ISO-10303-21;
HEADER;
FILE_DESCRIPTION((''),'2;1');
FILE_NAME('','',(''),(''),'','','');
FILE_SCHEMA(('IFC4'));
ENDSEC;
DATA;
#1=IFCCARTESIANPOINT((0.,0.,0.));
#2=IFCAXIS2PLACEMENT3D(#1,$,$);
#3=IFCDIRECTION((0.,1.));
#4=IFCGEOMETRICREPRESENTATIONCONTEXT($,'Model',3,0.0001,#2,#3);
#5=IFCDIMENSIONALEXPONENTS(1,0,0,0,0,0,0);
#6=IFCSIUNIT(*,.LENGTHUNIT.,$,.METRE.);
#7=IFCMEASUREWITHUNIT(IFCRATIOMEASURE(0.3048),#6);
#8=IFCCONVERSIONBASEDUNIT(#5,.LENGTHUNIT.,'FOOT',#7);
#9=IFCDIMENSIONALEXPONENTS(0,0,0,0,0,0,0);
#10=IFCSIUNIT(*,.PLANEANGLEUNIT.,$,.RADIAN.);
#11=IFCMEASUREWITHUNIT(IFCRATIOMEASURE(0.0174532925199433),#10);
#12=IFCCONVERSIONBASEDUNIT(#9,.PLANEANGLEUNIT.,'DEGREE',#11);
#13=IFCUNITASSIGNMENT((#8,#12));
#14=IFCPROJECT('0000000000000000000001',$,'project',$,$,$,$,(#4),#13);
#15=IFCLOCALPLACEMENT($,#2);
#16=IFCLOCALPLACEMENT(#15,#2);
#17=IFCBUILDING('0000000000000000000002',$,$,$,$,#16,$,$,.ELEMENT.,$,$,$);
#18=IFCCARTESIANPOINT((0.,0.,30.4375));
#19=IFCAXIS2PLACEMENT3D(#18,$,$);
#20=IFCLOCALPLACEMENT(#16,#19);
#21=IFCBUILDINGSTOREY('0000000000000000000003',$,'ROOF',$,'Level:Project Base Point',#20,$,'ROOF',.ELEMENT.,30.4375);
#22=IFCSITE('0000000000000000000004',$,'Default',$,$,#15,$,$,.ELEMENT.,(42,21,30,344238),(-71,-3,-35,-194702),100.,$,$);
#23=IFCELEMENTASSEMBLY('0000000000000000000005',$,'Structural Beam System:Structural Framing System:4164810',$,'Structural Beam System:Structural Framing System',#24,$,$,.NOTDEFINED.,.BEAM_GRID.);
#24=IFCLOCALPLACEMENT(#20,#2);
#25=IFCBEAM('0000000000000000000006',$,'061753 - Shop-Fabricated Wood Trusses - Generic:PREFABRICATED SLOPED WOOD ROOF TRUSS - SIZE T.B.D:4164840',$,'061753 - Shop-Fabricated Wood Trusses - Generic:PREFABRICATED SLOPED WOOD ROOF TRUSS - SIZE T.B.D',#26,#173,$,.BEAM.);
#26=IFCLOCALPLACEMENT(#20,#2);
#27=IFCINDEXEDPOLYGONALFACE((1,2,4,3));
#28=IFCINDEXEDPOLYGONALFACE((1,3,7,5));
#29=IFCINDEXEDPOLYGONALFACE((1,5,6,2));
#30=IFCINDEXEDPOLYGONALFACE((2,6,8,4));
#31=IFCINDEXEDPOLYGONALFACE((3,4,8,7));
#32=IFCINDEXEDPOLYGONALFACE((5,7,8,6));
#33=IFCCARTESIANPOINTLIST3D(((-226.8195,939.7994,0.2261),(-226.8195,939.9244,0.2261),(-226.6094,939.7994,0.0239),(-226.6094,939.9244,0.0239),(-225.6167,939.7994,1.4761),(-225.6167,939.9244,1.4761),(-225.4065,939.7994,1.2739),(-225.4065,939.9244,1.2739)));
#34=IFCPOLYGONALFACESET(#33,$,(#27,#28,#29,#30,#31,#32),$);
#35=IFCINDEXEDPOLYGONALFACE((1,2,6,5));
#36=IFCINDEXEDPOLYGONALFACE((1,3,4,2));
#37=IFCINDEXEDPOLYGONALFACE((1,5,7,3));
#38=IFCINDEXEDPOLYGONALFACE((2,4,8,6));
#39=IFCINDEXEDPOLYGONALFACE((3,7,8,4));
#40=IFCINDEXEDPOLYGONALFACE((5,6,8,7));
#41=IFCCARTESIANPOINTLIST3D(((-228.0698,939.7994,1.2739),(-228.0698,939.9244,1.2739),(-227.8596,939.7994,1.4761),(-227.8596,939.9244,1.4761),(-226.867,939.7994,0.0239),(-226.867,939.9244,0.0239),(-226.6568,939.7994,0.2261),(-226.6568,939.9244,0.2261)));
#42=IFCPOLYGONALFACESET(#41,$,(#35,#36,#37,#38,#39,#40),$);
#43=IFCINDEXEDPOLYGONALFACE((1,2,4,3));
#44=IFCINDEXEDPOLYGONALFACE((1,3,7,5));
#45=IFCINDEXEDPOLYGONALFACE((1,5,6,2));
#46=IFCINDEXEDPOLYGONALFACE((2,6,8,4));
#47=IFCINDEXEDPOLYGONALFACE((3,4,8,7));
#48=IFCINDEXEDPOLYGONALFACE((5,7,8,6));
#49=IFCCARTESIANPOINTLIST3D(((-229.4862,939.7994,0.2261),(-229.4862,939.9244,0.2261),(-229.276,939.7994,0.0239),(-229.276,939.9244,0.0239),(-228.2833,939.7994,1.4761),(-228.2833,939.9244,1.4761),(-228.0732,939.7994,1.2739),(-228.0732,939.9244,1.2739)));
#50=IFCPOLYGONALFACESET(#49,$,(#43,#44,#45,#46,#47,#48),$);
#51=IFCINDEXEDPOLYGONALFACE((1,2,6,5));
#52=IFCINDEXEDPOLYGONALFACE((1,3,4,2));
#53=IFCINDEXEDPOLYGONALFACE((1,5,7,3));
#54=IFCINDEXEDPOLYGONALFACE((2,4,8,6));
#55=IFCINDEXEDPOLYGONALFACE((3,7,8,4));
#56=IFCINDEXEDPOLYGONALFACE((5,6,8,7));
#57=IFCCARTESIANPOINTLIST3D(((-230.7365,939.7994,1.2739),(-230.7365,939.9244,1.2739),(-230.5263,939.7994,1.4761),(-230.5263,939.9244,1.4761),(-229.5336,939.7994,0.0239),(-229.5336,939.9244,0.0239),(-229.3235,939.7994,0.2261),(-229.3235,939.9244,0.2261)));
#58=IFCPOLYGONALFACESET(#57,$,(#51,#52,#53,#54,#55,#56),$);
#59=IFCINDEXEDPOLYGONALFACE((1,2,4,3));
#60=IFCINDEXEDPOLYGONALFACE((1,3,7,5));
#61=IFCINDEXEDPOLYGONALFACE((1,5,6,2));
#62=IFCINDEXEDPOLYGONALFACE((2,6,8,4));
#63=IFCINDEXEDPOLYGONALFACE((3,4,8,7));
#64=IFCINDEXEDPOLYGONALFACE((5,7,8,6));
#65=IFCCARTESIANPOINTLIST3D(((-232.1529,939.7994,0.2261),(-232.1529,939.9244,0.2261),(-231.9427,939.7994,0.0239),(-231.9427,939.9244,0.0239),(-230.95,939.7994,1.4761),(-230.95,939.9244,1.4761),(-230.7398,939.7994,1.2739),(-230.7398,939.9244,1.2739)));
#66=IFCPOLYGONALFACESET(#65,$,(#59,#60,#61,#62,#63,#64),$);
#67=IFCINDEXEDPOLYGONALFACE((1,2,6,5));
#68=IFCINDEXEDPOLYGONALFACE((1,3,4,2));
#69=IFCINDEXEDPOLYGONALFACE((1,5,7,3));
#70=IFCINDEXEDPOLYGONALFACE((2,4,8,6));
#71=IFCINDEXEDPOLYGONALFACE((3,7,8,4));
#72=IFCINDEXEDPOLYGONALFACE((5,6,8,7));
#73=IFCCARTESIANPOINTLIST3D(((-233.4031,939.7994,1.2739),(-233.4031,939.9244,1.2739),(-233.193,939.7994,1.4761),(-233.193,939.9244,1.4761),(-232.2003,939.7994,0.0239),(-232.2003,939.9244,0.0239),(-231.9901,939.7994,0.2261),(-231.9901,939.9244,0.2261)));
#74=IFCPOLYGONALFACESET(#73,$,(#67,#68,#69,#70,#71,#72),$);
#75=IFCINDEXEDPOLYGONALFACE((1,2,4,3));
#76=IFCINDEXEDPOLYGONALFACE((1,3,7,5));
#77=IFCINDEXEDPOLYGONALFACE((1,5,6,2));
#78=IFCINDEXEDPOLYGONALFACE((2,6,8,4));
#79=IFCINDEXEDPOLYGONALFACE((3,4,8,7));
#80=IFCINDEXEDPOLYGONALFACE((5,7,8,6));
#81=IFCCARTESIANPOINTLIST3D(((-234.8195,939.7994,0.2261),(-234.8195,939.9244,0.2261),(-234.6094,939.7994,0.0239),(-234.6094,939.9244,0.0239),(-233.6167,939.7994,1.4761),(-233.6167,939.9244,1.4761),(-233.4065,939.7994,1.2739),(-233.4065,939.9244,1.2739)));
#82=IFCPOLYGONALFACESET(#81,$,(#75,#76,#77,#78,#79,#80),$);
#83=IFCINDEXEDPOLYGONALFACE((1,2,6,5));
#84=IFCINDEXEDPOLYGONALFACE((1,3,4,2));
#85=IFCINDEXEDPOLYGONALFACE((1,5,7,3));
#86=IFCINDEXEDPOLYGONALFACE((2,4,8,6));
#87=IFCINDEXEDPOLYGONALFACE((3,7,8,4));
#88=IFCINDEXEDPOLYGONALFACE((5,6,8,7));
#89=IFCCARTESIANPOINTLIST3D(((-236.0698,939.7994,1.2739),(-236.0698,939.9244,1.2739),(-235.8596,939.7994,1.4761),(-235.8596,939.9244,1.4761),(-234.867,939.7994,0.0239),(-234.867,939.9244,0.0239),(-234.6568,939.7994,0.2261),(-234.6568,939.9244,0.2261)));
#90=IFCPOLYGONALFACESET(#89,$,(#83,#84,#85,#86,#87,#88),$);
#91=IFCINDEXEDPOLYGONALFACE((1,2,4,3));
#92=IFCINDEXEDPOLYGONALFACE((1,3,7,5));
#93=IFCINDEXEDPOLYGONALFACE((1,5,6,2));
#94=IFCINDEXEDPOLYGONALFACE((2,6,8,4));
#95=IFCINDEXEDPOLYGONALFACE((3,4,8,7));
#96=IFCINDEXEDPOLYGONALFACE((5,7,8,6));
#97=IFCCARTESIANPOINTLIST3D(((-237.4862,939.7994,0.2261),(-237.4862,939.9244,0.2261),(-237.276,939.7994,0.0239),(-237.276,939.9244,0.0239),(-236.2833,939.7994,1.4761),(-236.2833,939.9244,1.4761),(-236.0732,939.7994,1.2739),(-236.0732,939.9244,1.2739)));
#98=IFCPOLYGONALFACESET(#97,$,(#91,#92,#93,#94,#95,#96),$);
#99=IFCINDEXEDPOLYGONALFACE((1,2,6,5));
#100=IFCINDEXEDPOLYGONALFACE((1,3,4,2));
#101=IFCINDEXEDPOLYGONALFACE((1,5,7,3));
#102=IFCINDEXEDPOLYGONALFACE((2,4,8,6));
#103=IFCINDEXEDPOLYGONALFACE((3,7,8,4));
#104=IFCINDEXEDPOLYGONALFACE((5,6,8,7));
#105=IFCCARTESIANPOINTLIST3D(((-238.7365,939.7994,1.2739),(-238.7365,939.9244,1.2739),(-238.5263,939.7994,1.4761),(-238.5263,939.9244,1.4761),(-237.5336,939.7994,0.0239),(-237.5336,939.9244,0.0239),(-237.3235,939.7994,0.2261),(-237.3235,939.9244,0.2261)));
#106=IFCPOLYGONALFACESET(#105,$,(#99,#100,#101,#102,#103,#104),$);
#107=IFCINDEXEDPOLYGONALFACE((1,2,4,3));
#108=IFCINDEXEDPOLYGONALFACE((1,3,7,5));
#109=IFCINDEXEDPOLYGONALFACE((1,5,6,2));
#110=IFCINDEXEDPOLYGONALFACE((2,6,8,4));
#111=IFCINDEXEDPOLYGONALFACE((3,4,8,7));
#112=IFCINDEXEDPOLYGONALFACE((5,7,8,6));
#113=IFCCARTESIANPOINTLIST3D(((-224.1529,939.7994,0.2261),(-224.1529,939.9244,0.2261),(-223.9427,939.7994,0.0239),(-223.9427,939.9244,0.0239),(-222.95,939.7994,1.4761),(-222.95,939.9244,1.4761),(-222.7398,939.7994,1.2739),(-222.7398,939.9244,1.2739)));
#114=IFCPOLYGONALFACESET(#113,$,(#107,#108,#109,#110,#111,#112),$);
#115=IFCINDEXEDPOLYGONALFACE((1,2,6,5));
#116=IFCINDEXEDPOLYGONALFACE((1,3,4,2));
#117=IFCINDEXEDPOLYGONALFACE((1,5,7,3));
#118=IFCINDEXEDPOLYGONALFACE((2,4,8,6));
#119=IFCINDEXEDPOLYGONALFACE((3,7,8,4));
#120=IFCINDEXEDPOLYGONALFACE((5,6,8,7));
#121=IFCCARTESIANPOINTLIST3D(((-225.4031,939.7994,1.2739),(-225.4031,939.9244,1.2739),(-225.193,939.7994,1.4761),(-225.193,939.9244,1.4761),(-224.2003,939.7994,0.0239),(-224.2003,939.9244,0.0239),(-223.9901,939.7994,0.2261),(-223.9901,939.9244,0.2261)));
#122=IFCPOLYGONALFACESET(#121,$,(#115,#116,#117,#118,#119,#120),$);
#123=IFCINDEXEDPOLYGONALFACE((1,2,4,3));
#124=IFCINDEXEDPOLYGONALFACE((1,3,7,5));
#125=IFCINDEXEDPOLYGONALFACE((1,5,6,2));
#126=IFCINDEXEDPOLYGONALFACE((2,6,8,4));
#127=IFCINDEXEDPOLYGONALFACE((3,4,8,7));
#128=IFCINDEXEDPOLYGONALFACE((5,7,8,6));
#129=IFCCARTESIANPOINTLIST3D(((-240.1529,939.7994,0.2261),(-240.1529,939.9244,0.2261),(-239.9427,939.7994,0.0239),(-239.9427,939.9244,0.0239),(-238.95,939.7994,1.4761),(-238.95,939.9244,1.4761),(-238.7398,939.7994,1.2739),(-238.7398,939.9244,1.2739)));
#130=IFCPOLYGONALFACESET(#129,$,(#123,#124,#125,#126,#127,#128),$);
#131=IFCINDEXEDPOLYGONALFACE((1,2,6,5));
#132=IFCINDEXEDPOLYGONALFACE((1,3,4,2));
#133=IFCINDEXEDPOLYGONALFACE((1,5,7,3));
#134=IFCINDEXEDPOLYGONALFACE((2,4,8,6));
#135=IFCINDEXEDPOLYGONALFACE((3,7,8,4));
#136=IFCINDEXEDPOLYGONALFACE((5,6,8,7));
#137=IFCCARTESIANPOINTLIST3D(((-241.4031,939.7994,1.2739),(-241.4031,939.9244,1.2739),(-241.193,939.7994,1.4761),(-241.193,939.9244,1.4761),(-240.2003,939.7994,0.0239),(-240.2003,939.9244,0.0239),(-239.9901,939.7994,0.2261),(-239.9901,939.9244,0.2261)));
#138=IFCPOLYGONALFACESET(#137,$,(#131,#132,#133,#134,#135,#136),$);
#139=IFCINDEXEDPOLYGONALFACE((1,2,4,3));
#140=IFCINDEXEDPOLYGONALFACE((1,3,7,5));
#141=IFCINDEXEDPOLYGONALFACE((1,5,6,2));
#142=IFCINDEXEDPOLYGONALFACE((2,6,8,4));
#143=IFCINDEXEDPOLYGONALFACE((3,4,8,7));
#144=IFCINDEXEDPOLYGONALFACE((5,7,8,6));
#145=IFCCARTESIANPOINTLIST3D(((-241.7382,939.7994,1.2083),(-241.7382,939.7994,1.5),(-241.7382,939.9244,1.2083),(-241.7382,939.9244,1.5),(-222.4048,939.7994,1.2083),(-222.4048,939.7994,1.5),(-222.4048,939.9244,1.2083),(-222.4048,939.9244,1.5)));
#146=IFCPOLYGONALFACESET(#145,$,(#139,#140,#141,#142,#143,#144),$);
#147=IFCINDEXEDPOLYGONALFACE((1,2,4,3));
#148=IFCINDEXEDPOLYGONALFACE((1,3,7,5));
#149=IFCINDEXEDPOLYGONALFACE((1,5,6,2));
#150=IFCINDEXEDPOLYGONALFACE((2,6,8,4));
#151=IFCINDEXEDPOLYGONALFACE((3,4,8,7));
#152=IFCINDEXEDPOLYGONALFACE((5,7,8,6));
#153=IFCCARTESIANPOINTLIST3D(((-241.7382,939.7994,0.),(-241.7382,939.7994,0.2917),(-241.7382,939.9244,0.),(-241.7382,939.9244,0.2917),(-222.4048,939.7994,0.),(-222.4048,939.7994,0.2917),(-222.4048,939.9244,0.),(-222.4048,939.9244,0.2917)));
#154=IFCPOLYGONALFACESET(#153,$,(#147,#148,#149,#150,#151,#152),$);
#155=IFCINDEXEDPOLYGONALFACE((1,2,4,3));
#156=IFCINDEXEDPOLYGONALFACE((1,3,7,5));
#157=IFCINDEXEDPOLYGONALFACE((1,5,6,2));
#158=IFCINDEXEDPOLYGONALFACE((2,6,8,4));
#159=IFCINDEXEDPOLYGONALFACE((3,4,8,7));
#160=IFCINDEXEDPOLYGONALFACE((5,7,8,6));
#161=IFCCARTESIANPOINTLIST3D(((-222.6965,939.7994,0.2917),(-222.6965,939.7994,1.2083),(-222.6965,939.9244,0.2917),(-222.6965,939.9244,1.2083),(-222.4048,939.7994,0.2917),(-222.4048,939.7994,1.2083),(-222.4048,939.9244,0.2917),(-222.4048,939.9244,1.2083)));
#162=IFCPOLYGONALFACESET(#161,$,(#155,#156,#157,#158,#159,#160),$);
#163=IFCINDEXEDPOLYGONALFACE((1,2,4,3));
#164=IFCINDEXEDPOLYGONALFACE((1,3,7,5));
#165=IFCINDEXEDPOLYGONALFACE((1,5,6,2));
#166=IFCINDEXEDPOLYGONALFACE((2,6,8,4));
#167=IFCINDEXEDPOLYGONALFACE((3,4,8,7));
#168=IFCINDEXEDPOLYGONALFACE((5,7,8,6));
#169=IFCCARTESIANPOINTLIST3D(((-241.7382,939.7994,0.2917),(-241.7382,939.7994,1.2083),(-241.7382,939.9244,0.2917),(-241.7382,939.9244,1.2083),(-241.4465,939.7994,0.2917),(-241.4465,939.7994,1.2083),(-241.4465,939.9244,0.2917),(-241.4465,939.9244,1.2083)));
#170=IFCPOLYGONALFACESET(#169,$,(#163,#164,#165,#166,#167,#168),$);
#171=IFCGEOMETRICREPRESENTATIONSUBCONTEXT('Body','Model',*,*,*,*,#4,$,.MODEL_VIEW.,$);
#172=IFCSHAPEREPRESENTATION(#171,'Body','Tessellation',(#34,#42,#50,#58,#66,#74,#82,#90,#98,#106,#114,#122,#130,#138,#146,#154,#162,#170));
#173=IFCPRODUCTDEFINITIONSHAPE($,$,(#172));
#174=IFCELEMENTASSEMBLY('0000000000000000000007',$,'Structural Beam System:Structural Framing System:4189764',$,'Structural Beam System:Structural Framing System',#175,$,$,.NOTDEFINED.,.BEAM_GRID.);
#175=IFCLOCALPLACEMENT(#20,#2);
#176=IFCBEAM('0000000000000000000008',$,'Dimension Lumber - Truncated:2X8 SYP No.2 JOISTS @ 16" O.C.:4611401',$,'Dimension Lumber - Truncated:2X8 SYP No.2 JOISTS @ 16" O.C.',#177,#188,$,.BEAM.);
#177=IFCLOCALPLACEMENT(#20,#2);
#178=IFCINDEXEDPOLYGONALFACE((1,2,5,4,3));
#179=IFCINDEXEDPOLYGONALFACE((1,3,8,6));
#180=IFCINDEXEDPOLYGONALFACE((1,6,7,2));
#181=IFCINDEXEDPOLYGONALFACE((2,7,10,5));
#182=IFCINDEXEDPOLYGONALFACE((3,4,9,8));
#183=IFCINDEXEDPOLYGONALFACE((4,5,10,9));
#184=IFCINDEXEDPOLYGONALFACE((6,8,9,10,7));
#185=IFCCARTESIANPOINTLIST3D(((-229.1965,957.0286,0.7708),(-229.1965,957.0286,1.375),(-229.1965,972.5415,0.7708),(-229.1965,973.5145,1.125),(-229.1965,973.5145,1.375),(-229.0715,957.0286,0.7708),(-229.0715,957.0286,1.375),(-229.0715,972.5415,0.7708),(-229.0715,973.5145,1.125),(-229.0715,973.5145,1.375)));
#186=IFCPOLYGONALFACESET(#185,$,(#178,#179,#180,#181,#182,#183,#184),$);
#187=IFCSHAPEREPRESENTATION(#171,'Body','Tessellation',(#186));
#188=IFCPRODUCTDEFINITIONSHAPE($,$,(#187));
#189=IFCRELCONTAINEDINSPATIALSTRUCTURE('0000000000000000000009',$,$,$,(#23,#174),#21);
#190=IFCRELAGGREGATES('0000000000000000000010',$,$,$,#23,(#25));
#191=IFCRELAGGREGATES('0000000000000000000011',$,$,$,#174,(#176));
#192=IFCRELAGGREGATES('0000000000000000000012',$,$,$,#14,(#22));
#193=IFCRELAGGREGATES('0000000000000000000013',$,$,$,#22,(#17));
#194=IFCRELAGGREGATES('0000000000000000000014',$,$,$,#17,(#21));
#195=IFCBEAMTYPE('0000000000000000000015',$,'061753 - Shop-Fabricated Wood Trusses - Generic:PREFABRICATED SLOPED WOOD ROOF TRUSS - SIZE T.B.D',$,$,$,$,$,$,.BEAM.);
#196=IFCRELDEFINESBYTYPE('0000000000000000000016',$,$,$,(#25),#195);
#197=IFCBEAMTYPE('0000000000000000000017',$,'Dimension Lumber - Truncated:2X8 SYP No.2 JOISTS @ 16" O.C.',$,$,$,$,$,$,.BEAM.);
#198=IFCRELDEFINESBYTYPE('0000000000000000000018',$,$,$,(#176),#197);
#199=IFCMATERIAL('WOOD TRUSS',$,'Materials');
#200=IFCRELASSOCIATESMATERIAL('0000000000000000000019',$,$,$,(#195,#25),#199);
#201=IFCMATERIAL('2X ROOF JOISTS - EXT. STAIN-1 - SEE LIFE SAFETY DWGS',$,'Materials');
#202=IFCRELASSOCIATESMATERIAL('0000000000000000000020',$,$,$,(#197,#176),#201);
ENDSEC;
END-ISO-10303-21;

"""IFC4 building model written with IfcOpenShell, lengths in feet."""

from ifc_helpers import new_model, entity, si_unit, converted_unit, direction, frame, frame_2d, origin, origin_2d_with_axis, place, context, subcontext, project, spatial, rectangle, extrude, clip, halfspace, source, transform, mapped, material, material_profile, profile_set, profile_usage, type_object, type_shapes, element, aggregate, save


model = new_model("IFC4")

# Units and contexts
model_context = context("Model", 3, precision=0.0001, world=origin(), true_north=direction((0.0, 1.0)))
body_context = subcontext(model_context, "Body", "Model", "MODEL_VIEW")
ifc_project = project(units=[converted_unit("LENGTHUNIT", "FOOT", entity("IfcRatioMeasure", 0.3048), si_unit("LENGTHUNIT", "METRE"), dimensions=[1, 0, 0, 0, 0, 0, 0]), converted_unit("PLANEANGLEUNIT", "DEGREE", entity("IfcRatioMeasure", 0.0174532925199433), si_unit("PLANEANGLEUNIT", "RADIAN"), dimensions=[0, 0, 0, 0, 0, 0, 0])], contexts=[model_context])

# Site, building, storey
site_placement = place(None, origin())
site = spatial("IfcSite", under=ifc_project, at=site_placement, Name="Default", CompositionType="ELEMENT", RefLatitude=(42, 21, 30, 344238), RefLongitude=(-71, -3, -35, -194702), RefElevation=100.0)
building_placement = place(site_placement, origin())
building = spatial("IfcBuilding", under=site, at=building_placement, CompositionType="ELEMENT")
storey_placement = place(building_placement, frame((0.0, 0.0, 30.4375)))
storey = spatial("IfcBuildingStorey", under=building, at=storey_placement, Name="ROOF", ObjectType="Level:Project Base Point", LongName="ROOF", CompositionType="ELEMENT", Elevation=30.4375)

# Element assemblies, beams
assembly_1_placement = place(storey_placement, origin())
assembly_1 = element("IfcElementAssembly", 1, at=assembly_1_placement, inside=storey, Name="Structural Beam System:Structural Framing System:4164810", ObjectType="Structural Beam System:Structural Framing System", AssemblyPlace="NOTDEFINED", PredefinedType="BEAM_GRID")
ifc_material_1 = material(Name="WOOD TRUSS", Category="Materials")
ifc_material_profile_1 = material_profile(ifc_material_1, rectangle(XDim=1.7347, YDim=0.125, at=origin_2d_with_axis()), Name="PREFABRICATED SLOPED WOOD ROOF TRUSS - SIZE T.B.D")
ifc_material_profile_2 = material_profile(ifc_material_1, rectangle(XDim=1.7347, YDim=0.125, at=frame_2d((0.0, 0.0), x_axis=(1.0, 0.0))), Name="PREFABRICATED SLOPED WOOD ROOF TRUSS - SIZE T.B.D")
ifc_material_profile_3 = material_profile(ifc_material_1, rectangle(XDim=1.7347, YDim=0.125, at=origin_2d_with_axis()), Name="PREFABRICATED SLOPED WOOD ROOF TRUSS - SIZE T.B.D")
ifc_material_profile_4 = material_profile(ifc_material_1, rectangle(XDim=1.7347, YDim=0.125, at=origin_2d_with_axis()), Name="PREFABRICATED SLOPED WOOD ROOF TRUSS - SIZE T.B.D")
ifc_material_profile_5 = material_profile(ifc_material_1, rectangle(XDim=1.7347, YDim=0.125, at=frame_2d((0.0, 0.0), x_axis=(1.0, 0.0))), Name="PREFABRICATED SLOPED WOOD ROOF TRUSS - SIZE T.B.D")
ifc_material_profile_6 = material_profile(ifc_material_1, rectangle(XDim=1.7347, YDim=0.125, at=frame_2d((0.0, 0.0), x_axis=(1.0, 0.0))), Name="PREFABRICATED SLOPED WOOD ROOF TRUSS - SIZE T.B.D")
ifc_material_profile_7 = material_profile(ifc_material_1, rectangle(XDim=1.7347, YDim=0.125, at=frame_2d((0.0, 0.0), x_axis=(1.0, 0.0))), Name="PREFABRICATED SLOPED WOOD ROOF TRUSS - SIZE T.B.D")
ifc_material_profile_8 = material_profile(ifc_material_1, rectangle(XDim=1.7347, YDim=0.125, at=frame_2d((0.0, 0.0), x_axis=(1.0, 0.0))), Name="PREFABRICATED SLOPED WOOD ROOF TRUSS - SIZE T.B.D")
ifc_material_profile_9 = material_profile(ifc_material_1, rectangle(XDim=1.7347, YDim=0.125, at=origin_2d_with_axis()), Name="PREFABRICATED SLOPED WOOD ROOF TRUSS - SIZE T.B.D")
ifc_material_profile_10 = material_profile(ifc_material_1, rectangle(XDim=1.7347, YDim=0.125, at=frame_2d((0.0, 0.0), x_axis=(1.0, 0.0))), Name="PREFABRICATED SLOPED WOOD ROOF TRUSS - SIZE T.B.D")
ifc_material_profile_11 = material_profile(ifc_material_1, rectangle(XDim=0.2917, YDim=0.125, at=frame_2d((0.0, 0.0), x_axis=(1.0, 0.0))), Name="PREFABRICATED SLOPED WOOD ROOF TRUSS - SIZE T.B.D")
ifc_material_profile_12 = material_profile(ifc_material_1, rectangle(XDim=0.2917, YDim=0.125, at=frame_2d((0.0, 0.0), x_axis=(1.0, 0.0))), Name="PREFABRICATED SLOPED WOOD ROOF TRUSS - SIZE T.B.D")
ifc_material_profile_13 = material_profile(ifc_material_1, rectangle(XDim=0.9167, YDim=0.125, at=frame_2d((0.0, 0.0), x_axis=(1.0, 0.0))), Name="PREFABRICATED SLOPED WOOD ROOF TRUSS - SIZE T.B.D")
ifc_material_profile_14 = material_profile(ifc_material_1, rectangle(XDim=0.9167, YDim=0.125, at=frame_2d((0.0, 0.0), x_axis=(1.0, 0.0))), Name="PREFABRICATED SLOPED WOOD ROOF TRUSS - SIZE T.B.D")
ifc_profile_set_1 = profile_set([ifc_material_profile_1, ifc_material_profile_2, ifc_material_profile_3, ifc_material_profile_4, ifc_material_profile_5, ifc_material_profile_6, ifc_material_profile_7, ifc_material_profile_8, ifc_material_profile_9, ifc_material_profile_10, ifc_material_profile_11, ifc_material_profile_12, ifc_material_profile_13, ifc_material_profile_14], Name="PREFABRICATED SLOPED WOOD ROOF TRUSS - SIZE T.B.D")
beam_type_1 = type_object("IfcBeamType", Name="061753 - Shop-Fabricated Wood Trusses - Generic:PREFABRICATED SLOPED WOOD ROOF TRUSS - SIZE T.B.D", PredefinedType="BEAM", material=ifc_profile_set_1)
shared_shape_1 = source(origin(), body_context, "Body", "SweptSolid", [
    extrude(rectangle(XDim=1.7347, YDim=0.125, at=frame_2d((0.0, 0.0), x_axis=(1.0, 0.0))), frame((5.8534, 0.0, 0.1011), z_axis=(0.720569, 0.0, -0.693383), x_axis=(0.693383, 0.0, 0.720569)), (0.0, 0.0, 1.0), 0.2917),
    extrude(rectangle(XDim=1.7347, YDim=0.125, at=frame_2d((0.0, 0.0), x_axis=(1.0, 0.0))), frame((4.6031, 0.0, -0.1011), z_axis=(0.720569, 0.0, 0.693383), x_axis=(0.693383, 0.0, -0.720569)), (0.0, 0.0, 1.0), 0.2917),
    extrude(rectangle(XDim=1.7347, YDim=0.125, at=frame_2d((0.0, 0.0), x_axis=(1.0, 0.0))), frame((3.1867, 0.0, 0.1011), z_axis=(0.720569, 0.0, -0.693383), x_axis=(0.693383, 0.0, 0.720569)), (0.0, 0.0, 1.0), 0.2917),
    extrude(rectangle(XDim=1.7347, YDim=0.125, at=frame_2d((0.0, 0.0), x_axis=(1.0, 0.0))), frame((1.9364, 0.0, -0.1011), z_axis=(0.720569, 0.0, 0.693383), x_axis=(0.693383, 0.0, -0.720569)), (0.0, 0.0, 1.0), 0.2917),
    extrude(rectangle(XDim=1.7347, YDim=0.125, at=frame_2d((0.0, 0.0), x_axis=(1.0, 0.0))), frame((0.5201, 0.0, 0.1011), z_axis=(0.720569, 0.0, -0.693383), x_axis=(0.693383, 0.0, 0.720569)), (0.0, 0.0, 1.0), 0.2917),
    extrude(rectangle(XDim=1.7347, YDim=0.125, at=origin_2d_with_axis()), frame((-0.7302, 0.0, -0.1011), z_axis=(0.720569, 0.0, 0.693383), x_axis=(0.693383, 0.0, -0.720569)), (0.0, 0.0, 1.0), 0.2917),
    extrude(rectangle(XDim=1.7347, YDim=0.125, at=frame_2d((0.0, 0.0), x_axis=(1.0, 0.0))), frame((-2.1466, 0.0, 0.1011), z_axis=(0.720569, 0.0, -0.693383), x_axis=(0.693383, 0.0, 0.720569)), (0.0, 0.0, 1.0), 0.2917),
    extrude(rectangle(XDim=1.7347, YDim=0.125, at=frame_2d((0.0, 0.0), x_axis=(1.0, 0.0))), frame((-3.3969, 0.0, -0.1011), z_axis=(0.720569, 0.0, 0.693383), x_axis=(0.693383, 0.0, -0.720569)), (0.0, 0.0, 1.0), 0.2917),
    extrude(rectangle(XDim=1.7347, YDim=0.125, at=origin_2d_with_axis()), frame((-4.8133, 0.0, 0.1011), z_axis=(0.720569, 0.0, -0.693383), x_axis=(0.693383, 0.0, 0.720569)), (0.0, 0.0, 1.0), 0.2917),
    extrude(rectangle(XDim=1.7347, YDim=0.125, at=frame_2d((0.0, 0.0), x_axis=(1.0, 0.0))), frame((-6.0636, 0.0, -0.1011), z_axis=(0.720569, 0.0, 0.693383), x_axis=(0.693383, 0.0, -0.720569)), (0.0, 0.0, 1.0), 0.2917),
    extrude(rectangle(XDim=1.7347, YDim=0.125, at=frame_2d((0.0, 0.0), x_axis=(1.0, 0.0))), frame((8.5201, 0.0, 0.1011), z_axis=(0.720569, 0.0, -0.693383), x_axis=(0.693383, 0.0, 0.720569)), (0.0, 0.0, 1.0), 0.2917),
    extrude(rectangle(XDim=1.7347, YDim=0.125, at=origin_2d_with_axis()), frame((7.2698, 0.0, -0.1011), z_axis=(0.720569, 0.0, 0.693383), x_axis=(0.693383, 0.0, -0.720569)), (0.0, 0.0, 1.0), 0.2917),
    extrude(rectangle(XDim=1.7347, YDim=0.125, at=frame_2d((0.0, 0.0), x_axis=(1.0, 0.0))), frame((-7.4799, 0.0, 0.1011), z_axis=(0.720569, 0.0, -0.693383), x_axis=(0.693383, 0.0, 0.720569)), (0.0, 0.0, 1.0), 0.2917),
    extrude(rectangle(XDim=1.7347, YDim=0.125, at=origin_2d_with_axis()), frame((-8.7302, 0.0, -0.1011), z_axis=(0.720569, 0.0, 0.693383), x_axis=(0.693383, 0.0, -0.720569)), (0.0, 0.0, 1.0), 0.2917),
    extrude(rectangle(XDim=0.2917, YDim=0.125, at=frame_2d((0.0, 0.0), x_axis=(1.0, 0.0))), frame((-9.6667, 0.0, 0.6042), z_axis=(1.0, 0.0, 0.0), x_axis=(0.0, 0.0, -1.0)), (0.0, 0.0, 1.0), 19.3333),
    extrude(rectangle(XDim=0.2917, YDim=0.125, at=frame_2d((0.0, 0.0), x_axis=(1.0, 0.0))), frame((-9.6667, 0.0, -0.6042), z_axis=(1.0, 0.0, 0.0), x_axis=(0.0, 0.0, -1.0)), (0.0, 0.0, 1.0), 19.3333),
    extrude(rectangle(XDim=0.9167, YDim=0.125, at=frame_2d((0.0, 0.0), x_axis=(1.0, 0.0))), frame((9.375, 0.0, 0.0), z_axis=(1.0, 0.0, 0.0), x_axis=(0.0, 0.0, -1.0)), (0.0, 0.0, 1.0), 0.2917),
    extrude(rectangle(XDim=0.9167, YDim=0.125, at=frame_2d((0.0, 0.0), x_axis=(1.0, 0.0))), frame((-9.6667, 0.0, 0.0), z_axis=(1.0, 0.0, 0.0), x_axis=(0.0, 0.0, -1.0)), (0.0, 0.0, 1.0), 0.2917),
])
type_shapes(beam_type_1, [shared_shape_1])
ifc_profile_usage_1 = profile_usage(ifc_profile_set_1, cardinal=8)
beam_1_placement = place(assembly_1_placement, frame((-232.0715, 939.8619, 0.75)))
beam_1 = element("IfcBeam", 2, at=beam_1_placement, type_object=beam_type_1, material=ifc_profile_usage_1, Name="061753 - Shop-Fabricated Wood Trusses - Generic:PREFABRICATED SLOPED WOOD ROOF TRUSS - SIZE T.B.D:4164840", ObjectType="061753 - Shop-Fabricated Wood Trusses - Generic:PREFABRICATED SLOPED WOOD ROOF TRUSS - SIZE T.B.D", PredefinedType="BEAM", context=body_context, shape_type="MappedRepresentation", body=[
    mapped(shared_shape_1, transform((0.0, 0.0, 0.0), scale=1.0)),
])
aggregate(assembly_1, [beam_1])
assembly_2_placement = place(storey_placement, origin())
assembly_2 = element("IfcElementAssembly", 3, at=assembly_2_placement, inside=storey, Name="Structural Beam System:Structural Framing System:4189764", ObjectType="Structural Beam System:Structural Framing System", AssemblyPlace="NOTDEFINED", PredefinedType="BEAM_GRID")
ifc_material_2 = material(Name="2X ROOF JOISTS - EXT. STAIN-1 - SEE LIFE SAFETY DWGS", Category="Materials")
ifc_material_profile_15 = material_profile(ifc_material_2, rectangle(XDim=0.6042, YDim=0.125, at=frame_2d((0.0, 0.0), x_axis=(0.0, 1.0))), Name="2X8 SYP No.2 JOISTS @ 16\" O.C.")
ifc_profile_set_2 = profile_set([ifc_material_profile_15], Name="2X8 SYP No.2 JOISTS @ 16\" O.C.")
ifc_profile_usage_2 = profile_usage(ifc_profile_set_2, cardinal=8)
beam_type_2 = type_object("IfcBeamType", Name="Dimension Lumber - Truncated:2X8 SYP No.2 JOISTS @ 16\" O.C.", PredefinedType="BEAM", material=ifc_profile_set_2)
shared_shape_2 = source(origin(), body_context, "Body", "Clipping", [
    clip(extrude(rectangle(XDim=0.6042, YDim=0.125, at=frame_2d((0.0, 0.0), x_axis=(0.0, 1.0))), frame((-8.243, 0.0, 0.0), z_axis=(1.0, 0.0, 0.0), x_axis=(0.0, 1.0, 0.0)), (0.0, 0.0, 1.0), 16.4859), halfspace(frame((-7.2699, -0.0625, -0.3021), z_axis=(-0.34202, 0.0, -0.939693), x_axis=(0.0, 1.0, 0.0)), False)),
])
type_shapes(beam_type_2, [shared_shape_2])
beam_2_placement = place(assembly_2_placement, frame((-229.134, 965.2716, 1.0729), z_axis=(0.0, 0.0, 1.0), x_axis=(0.0, -1.0, 0.0)))
beam_2 = element("IfcBeam", 4, at=beam_2_placement, type_object=beam_type_2, material=ifc_profile_usage_2, Name="Dimension Lumber - Truncated:2X8 SYP No.2 JOISTS @ 16\" O.C.:4611401", ObjectType="Dimension Lumber - Truncated:2X8 SYP No.2 JOISTS @ 16\" O.C.", PredefinedType="BEAM", context=body_context, shape_type="MappedRepresentation", body=[
    mapped(shared_shape_2, transform((0.0, 0.0, 0.0), scale=1.0)),
])
aggregate(assembly_2, [beam_2])

save(model, "model.ifc")
